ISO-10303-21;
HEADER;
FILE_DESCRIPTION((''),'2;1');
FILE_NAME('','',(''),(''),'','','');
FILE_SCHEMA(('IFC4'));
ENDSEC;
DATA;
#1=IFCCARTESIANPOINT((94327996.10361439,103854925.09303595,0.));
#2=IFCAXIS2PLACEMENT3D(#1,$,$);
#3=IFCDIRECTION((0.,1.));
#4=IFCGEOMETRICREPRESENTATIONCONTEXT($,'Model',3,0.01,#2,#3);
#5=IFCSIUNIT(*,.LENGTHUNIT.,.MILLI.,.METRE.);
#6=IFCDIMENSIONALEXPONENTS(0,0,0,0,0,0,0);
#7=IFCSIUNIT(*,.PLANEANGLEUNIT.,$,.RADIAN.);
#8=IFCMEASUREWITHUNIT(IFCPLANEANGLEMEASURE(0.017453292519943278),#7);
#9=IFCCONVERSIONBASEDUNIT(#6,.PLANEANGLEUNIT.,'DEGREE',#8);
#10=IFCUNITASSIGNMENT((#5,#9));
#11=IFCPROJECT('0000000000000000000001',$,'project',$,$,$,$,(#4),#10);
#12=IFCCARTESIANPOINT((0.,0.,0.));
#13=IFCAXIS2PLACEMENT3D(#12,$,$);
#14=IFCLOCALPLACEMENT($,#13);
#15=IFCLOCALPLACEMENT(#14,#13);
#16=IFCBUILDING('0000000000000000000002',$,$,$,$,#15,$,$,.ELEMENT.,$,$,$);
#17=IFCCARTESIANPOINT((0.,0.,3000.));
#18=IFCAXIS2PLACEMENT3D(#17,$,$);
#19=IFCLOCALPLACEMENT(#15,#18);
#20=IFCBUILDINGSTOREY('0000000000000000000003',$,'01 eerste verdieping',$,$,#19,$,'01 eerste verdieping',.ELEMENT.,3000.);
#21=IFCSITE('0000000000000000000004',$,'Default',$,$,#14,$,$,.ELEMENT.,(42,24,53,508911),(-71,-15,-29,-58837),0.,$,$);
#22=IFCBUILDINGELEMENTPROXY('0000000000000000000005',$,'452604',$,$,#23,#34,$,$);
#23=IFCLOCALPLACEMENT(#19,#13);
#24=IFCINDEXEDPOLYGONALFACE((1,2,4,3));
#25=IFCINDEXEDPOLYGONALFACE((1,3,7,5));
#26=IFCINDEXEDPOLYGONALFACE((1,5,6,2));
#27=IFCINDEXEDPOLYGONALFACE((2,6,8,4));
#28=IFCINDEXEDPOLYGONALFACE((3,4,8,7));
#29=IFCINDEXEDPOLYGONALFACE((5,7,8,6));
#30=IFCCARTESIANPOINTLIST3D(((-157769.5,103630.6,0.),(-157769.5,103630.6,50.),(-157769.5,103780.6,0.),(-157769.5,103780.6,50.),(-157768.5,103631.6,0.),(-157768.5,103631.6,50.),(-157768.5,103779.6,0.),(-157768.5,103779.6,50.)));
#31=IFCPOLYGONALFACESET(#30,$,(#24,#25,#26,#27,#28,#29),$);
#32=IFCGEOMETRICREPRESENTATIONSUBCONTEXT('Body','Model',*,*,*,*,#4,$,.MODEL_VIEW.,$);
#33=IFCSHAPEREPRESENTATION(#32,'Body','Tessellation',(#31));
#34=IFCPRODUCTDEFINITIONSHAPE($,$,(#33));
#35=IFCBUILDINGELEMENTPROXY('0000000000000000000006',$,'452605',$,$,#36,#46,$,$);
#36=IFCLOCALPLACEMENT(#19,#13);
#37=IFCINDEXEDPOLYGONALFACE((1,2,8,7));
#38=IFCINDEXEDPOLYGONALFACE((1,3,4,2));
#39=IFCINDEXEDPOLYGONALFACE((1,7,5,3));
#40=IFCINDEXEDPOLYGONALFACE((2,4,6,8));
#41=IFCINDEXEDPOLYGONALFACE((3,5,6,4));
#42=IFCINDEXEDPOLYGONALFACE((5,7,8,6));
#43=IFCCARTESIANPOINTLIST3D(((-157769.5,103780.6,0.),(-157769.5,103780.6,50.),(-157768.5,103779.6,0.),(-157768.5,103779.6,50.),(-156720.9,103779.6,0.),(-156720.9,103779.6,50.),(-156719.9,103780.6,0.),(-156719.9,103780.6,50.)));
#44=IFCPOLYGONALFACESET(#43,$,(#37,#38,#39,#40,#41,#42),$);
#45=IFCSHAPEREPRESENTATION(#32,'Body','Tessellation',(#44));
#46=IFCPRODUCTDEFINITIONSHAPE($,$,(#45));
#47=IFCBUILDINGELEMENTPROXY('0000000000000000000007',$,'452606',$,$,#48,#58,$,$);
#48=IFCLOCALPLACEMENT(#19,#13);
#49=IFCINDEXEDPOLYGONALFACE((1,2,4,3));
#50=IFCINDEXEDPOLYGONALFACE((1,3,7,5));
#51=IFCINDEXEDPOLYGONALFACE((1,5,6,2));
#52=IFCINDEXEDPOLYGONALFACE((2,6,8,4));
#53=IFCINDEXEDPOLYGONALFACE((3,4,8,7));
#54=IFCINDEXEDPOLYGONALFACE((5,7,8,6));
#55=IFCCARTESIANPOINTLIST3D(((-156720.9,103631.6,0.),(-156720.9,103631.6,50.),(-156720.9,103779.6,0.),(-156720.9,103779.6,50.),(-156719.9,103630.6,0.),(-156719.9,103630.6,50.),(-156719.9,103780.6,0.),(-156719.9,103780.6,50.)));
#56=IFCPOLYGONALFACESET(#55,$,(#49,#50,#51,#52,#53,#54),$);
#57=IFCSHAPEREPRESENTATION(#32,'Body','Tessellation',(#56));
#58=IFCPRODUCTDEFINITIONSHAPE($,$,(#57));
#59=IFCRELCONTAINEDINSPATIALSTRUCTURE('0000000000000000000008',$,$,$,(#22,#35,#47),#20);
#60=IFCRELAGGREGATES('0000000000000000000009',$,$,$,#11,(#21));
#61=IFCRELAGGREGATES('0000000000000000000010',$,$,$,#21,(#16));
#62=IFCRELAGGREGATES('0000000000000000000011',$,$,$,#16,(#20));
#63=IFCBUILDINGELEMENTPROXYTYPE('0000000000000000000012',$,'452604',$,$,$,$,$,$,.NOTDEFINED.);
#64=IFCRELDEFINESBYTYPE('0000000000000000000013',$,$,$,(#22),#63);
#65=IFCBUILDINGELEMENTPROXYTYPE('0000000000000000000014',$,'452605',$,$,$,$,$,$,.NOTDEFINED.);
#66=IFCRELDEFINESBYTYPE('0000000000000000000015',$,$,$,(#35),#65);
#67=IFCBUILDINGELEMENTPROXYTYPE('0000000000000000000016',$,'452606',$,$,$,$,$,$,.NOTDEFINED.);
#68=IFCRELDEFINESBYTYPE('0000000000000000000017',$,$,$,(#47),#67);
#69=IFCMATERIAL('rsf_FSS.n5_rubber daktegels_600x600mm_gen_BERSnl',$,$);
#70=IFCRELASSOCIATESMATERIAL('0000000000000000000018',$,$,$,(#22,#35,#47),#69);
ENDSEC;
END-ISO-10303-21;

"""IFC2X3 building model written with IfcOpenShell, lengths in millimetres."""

from ifc_helpers import new_model, entity, si_unit, converted_unit, direction, frame, origin, place, context, subcontext, project, spatial, polyline, outline, extrude, material, type_object, element, save


model = new_model("IFC2X3")

# Units and contexts
model_context = context("Model", 3, precision=0.01, world=frame((94327996.10361439, 103854925.09303595, 0.0)), true_north=direction((0.0, 1.0)))
body_context = subcontext(model_context, "Body", "Model", "MODEL_VIEW")
ifc_project = project(units=[si_unit("LENGTHUNIT", "METRE", prefix="MILLI"), converted_unit("PLANEANGLEUNIT", "DEGREE", entity("IfcPlaneAngleMeasure", 0.017453292519943278), si_unit("PLANEANGLEUNIT", "RADIAN"), dimensions=[0, 0, 0, 0, 0, 0, 0])], contexts=[model_context])

# Site, building, storey
site_placement = place(None, origin())
site = spatial("IfcSite", under=ifc_project, at=site_placement, Name="Default", CompositionType="ELEMENT", RefLatitude=(42, 24, 53, 508911), RefLongitude=(-71, -15, -29, -58837), RefElevation=0.0)
building_placement = place(site_placement, origin())
building = spatial("IfcBuilding", under=site, at=building_placement, CompositionType="ELEMENT")
storey_placement = place(building_placement, frame((0.0, 0.0, 3000.0)))
storey = spatial("IfcBuildingStorey", under=building, at=storey_placement, Name="01 eerste verdieping", LongName="01 eerste verdieping", CompositionType="ELEMENT", Elevation=3000.0)

# Building element proxies
ifc_material = material(Name="rsf_FSS.n5_rubber daktegels_600x600mm_gen_BERSnl")
building_element_proxy_type_1 = type_object("IfcBuildingElementProxyType", Name="452604", PredefinedType="NOTDEFINED")
proxy_1_placement = place(storey_placement, origin())
element("IfcBuildingElementProxy", 1, at=proxy_1_placement, inside=storey, type_object=building_element_proxy_type_1, material=ifc_material, Name="452604", context=body_context, shape_type="SweptSolid", body=[
    extrude(outline(polyline([(-75.0, -0.5), (75.0, -0.5), (74.0, 0.5), (-74.0, 0.5), (-75.0, -0.5)])), frame((-157769.0, 103705.6, 0.0), z_axis=(0.0, 0.0, 1.0), x_axis=(0.0, -1.0, 0.0)), (0.0, 0.0, 1.0), 50.0),
])
building_element_proxy_type_2 = type_object("IfcBuildingElementProxyType", Name="452605", PredefinedType="NOTDEFINED")
proxy_2_placement = place(storey_placement, origin())
element("IfcBuildingElementProxy", 2, at=proxy_2_placement, inside=storey, type_object=building_element_proxy_type_2, material=ifc_material, Name="452605", context=body_context, shape_type="SweptSolid", body=[
    extrude(outline(polyline([(-524.8, -0.5), (524.8, -0.5), (523.8, 0.5), (-523.8, 0.5), (-524.8, -0.5)])), frame((-157244.7, 103780.1, 0.0), z_axis=(0.0, 0.0, 1.0), x_axis=(-1.0, 0.0, 0.0)), (0.0, 0.0, 1.0), 50.0),
])
building_element_proxy_type_3 = type_object("IfcBuildingElementProxyType", Name="452606", PredefinedType="NOTDEFINED")
proxy_3_placement = place(storey_placement, origin())
element("IfcBuildingElementProxy", 3, at=proxy_3_placement, inside=storey, type_object=building_element_proxy_type_3, material=ifc_material, Name="452606", context=body_context, shape_type="SweptSolid", body=[
    extrude(outline(polyline([(-75.0, -0.5), (75.0, -0.5), (74.0, 0.5), (-74.0, 0.5), (-75.0, -0.5)])), frame((-156720.4, 103705.6, 0.0), z_axis=(0.0, 0.0, 1.0), x_axis=(0.0, 1.0, 0.0)), (0.0, 0.0, 1.0), 50.0),
])

save(model, "model.ifc")
